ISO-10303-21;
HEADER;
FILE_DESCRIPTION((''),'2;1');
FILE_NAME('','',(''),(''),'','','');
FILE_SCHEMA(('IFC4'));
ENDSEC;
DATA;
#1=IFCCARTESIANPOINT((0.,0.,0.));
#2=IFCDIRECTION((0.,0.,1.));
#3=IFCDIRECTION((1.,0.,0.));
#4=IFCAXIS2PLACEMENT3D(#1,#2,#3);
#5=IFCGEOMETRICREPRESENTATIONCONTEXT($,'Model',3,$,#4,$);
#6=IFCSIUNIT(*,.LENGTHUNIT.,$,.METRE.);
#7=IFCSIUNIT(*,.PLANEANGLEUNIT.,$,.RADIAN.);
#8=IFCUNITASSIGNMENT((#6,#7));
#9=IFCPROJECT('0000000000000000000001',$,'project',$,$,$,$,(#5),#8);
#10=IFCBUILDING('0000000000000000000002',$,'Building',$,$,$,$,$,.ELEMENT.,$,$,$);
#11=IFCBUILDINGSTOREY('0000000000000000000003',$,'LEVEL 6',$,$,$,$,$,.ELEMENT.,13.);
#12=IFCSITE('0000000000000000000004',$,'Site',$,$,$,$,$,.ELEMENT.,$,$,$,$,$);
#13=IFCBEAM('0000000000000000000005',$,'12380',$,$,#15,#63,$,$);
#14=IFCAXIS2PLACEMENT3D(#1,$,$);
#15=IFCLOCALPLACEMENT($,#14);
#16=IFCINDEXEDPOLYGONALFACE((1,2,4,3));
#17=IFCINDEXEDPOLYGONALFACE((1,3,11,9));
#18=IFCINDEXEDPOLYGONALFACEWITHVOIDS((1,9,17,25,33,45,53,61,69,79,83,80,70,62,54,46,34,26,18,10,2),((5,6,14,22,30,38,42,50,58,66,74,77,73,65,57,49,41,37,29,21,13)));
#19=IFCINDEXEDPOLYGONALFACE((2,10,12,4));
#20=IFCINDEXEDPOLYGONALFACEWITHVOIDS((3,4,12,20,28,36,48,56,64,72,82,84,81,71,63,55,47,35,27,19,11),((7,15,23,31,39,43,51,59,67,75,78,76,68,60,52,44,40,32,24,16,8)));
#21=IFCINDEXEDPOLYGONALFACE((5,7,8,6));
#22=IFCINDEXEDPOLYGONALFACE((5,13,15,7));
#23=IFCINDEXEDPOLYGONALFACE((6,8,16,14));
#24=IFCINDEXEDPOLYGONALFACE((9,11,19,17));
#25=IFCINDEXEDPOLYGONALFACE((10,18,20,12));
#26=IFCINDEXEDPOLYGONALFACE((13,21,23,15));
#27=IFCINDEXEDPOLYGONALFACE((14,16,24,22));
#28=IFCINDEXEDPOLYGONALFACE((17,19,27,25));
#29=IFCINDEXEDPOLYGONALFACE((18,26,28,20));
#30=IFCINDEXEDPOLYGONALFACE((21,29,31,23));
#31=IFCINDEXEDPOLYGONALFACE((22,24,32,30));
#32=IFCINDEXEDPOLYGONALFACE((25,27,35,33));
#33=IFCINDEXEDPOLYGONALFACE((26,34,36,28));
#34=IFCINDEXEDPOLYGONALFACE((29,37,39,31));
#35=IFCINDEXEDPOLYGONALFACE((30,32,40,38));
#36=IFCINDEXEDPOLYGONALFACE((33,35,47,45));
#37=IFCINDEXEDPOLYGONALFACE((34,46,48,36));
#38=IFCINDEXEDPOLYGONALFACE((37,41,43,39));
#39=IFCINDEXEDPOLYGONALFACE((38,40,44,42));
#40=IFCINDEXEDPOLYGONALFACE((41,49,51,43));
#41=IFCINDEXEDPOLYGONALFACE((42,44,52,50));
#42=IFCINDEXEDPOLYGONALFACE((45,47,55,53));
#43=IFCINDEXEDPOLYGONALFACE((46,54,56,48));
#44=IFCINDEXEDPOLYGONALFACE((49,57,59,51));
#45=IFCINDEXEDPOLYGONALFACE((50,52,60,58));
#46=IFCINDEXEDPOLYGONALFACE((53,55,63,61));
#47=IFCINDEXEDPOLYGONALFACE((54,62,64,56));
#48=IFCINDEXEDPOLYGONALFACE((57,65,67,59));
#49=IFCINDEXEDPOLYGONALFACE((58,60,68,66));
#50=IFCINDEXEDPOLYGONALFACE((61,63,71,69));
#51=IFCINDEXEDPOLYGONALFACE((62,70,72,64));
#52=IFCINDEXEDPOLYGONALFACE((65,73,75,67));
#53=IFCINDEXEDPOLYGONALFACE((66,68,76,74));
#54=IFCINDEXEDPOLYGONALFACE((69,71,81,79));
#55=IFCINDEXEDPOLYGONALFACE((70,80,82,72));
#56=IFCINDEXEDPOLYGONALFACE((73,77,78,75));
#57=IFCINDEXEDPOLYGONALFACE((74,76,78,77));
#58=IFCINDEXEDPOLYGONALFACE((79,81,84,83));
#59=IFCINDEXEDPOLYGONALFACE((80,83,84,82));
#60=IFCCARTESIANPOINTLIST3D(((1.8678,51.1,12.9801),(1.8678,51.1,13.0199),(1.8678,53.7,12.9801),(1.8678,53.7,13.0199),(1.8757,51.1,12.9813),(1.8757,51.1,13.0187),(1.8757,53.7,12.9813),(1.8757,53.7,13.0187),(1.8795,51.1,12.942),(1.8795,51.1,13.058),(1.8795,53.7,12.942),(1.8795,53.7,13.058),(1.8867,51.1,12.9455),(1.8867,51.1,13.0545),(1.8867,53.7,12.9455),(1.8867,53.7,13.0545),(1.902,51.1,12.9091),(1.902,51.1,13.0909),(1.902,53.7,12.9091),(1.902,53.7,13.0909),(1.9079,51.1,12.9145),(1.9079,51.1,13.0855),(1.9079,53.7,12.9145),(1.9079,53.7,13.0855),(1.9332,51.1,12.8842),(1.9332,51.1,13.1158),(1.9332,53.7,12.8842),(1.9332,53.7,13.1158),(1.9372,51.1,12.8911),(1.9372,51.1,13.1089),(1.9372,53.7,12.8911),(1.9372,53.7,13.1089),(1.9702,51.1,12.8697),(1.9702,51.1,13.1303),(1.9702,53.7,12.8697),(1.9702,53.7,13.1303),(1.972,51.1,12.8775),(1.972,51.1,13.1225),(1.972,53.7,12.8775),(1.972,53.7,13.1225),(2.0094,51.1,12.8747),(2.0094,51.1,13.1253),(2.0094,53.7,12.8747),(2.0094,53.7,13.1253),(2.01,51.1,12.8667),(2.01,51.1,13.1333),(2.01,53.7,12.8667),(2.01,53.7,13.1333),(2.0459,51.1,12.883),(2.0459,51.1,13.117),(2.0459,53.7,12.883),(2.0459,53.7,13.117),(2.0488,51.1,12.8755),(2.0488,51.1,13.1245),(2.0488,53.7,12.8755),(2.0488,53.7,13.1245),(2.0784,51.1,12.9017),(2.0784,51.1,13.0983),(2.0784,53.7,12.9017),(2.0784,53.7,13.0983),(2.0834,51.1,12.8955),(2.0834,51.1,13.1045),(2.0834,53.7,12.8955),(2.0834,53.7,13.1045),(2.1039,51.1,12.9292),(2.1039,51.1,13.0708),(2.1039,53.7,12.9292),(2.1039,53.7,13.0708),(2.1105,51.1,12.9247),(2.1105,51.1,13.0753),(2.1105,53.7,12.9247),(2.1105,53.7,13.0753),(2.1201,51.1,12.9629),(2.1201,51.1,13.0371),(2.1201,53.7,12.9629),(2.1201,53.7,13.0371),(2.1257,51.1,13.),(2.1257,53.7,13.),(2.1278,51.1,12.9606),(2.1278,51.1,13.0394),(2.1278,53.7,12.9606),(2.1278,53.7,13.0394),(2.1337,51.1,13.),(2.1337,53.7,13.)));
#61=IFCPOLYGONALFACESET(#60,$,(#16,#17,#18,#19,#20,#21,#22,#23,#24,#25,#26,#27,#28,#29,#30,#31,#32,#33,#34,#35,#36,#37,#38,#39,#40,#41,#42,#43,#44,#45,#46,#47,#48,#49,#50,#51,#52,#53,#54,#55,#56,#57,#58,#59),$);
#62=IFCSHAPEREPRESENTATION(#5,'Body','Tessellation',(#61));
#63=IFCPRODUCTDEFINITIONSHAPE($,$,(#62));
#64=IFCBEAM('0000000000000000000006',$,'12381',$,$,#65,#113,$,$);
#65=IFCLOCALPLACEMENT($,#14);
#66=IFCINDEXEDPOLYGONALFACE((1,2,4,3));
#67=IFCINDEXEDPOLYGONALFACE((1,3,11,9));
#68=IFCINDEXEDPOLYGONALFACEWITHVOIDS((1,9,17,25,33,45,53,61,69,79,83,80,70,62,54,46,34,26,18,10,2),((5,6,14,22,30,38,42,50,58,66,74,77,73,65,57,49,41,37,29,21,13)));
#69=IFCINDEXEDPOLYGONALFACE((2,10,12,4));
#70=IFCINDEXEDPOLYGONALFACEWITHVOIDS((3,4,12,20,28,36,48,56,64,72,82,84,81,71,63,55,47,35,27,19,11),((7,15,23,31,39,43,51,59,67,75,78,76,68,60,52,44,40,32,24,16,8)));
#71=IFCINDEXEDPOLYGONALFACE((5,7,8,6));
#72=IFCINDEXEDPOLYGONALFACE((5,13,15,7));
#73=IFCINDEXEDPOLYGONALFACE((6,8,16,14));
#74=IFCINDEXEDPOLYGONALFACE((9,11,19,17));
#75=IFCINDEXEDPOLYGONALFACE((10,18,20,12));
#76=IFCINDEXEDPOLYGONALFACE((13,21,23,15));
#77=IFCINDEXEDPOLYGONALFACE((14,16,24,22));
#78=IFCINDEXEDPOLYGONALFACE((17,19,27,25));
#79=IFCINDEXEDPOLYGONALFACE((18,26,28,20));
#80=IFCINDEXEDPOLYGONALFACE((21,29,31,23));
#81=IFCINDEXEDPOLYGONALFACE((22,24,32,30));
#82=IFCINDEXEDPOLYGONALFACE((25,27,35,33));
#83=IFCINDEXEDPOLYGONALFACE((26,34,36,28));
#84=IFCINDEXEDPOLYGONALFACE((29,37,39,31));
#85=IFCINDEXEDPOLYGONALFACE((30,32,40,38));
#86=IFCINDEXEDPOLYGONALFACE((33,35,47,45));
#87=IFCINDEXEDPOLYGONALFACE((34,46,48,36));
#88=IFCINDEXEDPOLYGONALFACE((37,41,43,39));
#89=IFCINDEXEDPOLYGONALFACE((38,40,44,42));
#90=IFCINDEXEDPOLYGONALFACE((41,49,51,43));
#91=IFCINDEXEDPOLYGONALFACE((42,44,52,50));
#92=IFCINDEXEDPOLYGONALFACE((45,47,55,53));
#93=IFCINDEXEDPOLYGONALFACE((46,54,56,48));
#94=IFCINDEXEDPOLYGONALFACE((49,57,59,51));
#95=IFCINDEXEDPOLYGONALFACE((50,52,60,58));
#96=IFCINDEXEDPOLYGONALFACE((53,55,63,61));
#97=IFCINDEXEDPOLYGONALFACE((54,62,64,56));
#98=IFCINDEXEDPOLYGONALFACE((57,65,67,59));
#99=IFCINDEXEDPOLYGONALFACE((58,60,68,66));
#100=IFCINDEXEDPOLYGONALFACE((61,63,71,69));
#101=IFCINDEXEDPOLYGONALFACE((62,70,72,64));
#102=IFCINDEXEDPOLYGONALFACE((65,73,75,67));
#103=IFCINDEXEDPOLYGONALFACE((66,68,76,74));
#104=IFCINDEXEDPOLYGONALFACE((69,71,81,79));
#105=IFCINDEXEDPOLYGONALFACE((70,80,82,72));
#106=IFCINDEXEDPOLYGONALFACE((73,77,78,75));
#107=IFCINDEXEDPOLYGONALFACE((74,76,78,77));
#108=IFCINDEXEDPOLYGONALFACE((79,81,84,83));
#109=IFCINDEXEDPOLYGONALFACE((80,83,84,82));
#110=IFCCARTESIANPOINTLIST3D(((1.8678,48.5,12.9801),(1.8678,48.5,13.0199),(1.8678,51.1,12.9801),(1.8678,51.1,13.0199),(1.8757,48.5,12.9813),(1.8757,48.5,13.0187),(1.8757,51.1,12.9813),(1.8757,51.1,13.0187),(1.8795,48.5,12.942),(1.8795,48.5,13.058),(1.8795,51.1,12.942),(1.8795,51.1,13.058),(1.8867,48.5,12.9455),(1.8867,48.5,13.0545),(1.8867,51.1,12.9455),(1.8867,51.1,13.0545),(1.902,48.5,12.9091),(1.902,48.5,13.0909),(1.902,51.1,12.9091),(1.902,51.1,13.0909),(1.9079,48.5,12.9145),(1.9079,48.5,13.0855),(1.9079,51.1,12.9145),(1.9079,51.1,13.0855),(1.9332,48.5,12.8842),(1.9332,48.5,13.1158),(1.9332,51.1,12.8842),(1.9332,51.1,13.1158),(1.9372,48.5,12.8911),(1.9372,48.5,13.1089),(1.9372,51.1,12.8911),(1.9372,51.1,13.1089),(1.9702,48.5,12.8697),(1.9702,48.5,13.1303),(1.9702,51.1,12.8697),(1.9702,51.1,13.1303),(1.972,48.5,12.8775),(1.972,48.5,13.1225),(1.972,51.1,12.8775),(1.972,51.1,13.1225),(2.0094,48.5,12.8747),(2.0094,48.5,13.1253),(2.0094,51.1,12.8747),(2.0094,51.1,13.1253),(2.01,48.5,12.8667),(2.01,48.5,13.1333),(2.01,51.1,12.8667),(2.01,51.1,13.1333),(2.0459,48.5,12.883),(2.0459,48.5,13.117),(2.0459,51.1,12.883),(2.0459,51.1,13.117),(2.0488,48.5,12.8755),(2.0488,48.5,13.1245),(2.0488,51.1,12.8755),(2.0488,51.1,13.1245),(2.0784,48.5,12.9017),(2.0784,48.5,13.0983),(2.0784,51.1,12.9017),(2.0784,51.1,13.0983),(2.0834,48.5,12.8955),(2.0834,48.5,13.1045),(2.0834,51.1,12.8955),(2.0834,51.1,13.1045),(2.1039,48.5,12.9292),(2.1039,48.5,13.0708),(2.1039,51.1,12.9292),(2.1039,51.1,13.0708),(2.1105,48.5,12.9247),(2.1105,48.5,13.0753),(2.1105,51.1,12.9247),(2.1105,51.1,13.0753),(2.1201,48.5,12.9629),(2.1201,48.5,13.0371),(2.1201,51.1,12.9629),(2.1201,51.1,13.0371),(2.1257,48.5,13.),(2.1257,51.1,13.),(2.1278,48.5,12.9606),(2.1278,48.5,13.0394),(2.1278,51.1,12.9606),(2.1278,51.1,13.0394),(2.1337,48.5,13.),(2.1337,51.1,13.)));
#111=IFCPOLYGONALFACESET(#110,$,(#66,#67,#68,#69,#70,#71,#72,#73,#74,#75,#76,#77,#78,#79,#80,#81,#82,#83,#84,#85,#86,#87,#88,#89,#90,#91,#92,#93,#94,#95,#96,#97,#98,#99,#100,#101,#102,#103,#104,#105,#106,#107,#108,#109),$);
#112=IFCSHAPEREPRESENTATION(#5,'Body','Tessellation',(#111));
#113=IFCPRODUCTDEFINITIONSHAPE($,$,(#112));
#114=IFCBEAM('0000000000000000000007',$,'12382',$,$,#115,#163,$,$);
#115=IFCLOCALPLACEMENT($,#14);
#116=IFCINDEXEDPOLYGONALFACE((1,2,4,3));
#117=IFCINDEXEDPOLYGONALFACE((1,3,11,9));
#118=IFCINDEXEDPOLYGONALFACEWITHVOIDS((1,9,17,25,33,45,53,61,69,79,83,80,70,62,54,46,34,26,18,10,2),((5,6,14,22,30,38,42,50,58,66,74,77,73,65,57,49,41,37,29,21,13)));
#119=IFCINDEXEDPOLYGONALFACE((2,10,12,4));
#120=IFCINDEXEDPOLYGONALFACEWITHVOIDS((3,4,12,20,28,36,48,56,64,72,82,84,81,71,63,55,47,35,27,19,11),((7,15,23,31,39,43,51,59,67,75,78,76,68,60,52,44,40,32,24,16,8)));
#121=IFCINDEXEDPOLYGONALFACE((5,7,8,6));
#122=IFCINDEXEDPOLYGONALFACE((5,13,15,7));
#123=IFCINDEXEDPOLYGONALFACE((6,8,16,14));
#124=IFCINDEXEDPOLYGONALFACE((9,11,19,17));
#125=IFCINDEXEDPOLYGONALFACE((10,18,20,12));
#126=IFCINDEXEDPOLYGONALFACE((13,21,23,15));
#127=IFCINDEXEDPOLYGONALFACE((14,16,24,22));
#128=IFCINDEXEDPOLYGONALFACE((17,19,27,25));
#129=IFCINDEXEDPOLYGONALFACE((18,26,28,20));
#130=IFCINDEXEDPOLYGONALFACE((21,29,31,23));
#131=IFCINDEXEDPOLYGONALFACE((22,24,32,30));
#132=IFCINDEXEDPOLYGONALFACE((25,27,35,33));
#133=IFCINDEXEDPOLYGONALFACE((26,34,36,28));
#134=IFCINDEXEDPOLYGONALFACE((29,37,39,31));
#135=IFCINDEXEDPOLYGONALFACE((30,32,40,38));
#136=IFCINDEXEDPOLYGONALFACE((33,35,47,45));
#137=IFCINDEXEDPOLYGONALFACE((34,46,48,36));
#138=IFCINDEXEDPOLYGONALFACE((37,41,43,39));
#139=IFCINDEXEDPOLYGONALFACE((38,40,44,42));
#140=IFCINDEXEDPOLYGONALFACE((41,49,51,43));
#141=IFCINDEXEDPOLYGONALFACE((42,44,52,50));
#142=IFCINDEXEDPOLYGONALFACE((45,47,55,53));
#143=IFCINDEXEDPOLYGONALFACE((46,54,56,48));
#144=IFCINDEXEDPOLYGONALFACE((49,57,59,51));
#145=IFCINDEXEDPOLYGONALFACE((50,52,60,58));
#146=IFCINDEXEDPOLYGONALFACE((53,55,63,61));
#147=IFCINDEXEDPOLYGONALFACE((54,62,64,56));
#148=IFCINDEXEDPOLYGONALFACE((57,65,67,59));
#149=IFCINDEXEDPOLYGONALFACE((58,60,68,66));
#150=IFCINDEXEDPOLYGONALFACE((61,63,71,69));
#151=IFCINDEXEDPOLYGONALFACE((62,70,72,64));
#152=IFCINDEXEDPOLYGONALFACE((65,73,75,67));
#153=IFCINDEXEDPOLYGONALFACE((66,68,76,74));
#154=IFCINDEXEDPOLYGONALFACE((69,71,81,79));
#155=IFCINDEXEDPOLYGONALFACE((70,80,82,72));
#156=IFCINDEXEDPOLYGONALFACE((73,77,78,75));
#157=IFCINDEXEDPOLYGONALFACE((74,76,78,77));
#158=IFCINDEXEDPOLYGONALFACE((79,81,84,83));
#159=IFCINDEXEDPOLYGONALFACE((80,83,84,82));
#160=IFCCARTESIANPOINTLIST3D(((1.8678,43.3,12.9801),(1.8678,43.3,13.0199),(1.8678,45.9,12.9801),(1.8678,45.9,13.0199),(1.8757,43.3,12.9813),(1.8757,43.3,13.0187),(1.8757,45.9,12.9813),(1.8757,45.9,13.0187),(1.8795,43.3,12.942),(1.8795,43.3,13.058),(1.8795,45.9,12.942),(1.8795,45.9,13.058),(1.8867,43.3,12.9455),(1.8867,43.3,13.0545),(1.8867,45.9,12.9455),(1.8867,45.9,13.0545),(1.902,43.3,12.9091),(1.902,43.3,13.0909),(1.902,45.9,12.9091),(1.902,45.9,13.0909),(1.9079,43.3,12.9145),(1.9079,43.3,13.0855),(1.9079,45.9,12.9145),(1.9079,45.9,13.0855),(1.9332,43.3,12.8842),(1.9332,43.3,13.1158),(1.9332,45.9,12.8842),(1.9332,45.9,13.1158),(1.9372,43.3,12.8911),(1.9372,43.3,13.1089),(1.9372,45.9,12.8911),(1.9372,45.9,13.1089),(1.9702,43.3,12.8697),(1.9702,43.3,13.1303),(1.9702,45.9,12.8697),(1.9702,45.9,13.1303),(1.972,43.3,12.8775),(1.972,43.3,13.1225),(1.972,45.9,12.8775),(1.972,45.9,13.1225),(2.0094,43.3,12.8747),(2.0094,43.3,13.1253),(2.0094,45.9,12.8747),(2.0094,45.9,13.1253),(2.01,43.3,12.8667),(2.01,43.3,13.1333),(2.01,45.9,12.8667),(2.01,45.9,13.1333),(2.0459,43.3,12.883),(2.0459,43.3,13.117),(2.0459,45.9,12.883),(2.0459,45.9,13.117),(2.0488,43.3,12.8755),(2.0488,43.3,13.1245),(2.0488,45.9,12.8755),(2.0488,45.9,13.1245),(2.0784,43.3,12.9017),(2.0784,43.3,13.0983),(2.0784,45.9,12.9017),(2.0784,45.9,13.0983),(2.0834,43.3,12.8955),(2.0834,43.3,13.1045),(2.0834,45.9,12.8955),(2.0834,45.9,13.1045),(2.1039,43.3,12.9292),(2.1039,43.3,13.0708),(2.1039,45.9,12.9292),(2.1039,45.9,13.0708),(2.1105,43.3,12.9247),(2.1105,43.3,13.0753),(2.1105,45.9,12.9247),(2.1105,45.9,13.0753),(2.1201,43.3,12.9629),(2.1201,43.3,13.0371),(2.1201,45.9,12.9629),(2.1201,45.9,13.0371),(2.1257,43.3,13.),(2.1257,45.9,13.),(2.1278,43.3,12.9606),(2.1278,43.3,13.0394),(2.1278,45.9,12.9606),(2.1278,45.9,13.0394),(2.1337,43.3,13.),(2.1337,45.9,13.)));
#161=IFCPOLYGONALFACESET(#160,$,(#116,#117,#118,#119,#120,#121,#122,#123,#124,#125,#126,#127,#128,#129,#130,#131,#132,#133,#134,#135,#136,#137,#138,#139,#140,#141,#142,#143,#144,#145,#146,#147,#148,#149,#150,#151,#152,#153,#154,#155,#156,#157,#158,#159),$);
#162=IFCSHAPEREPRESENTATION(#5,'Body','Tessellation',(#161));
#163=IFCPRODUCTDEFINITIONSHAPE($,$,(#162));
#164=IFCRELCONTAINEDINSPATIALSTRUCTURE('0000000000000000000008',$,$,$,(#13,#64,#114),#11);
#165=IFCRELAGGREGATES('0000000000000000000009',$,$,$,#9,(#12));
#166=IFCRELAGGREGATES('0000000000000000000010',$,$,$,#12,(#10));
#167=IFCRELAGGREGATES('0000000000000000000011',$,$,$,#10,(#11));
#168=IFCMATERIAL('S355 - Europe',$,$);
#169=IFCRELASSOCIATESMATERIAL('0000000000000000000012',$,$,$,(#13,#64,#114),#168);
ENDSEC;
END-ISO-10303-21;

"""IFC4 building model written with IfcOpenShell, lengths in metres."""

from ifc_helpers import new_model, si_unit, frame, origin_with_axes, origin_2d_with_axis, place, context, project, spatial, hollow_circle, extrude, material, material_profile, profile_set, profile_usage, element, save


model = new_model("IFC4")

# Units and contexts
model_context = context("Model", 3, world=origin_with_axes())
ifc_project = project(units=[si_unit("LENGTHUNIT", "METRE"), si_unit("PLANEANGLEUNIT", "RADIAN")], contexts=[model_context])

# Site, building, storey
site = spatial("IfcSite", under=ifc_project, Name="Site", CompositionType="ELEMENT")
building = spatial("IfcBuilding", under=site, Name="Building", CompositionType="ELEMENT")
storey = spatial("IfcBuildingStorey", under=building, Name="LEVEL 6", CompositionType="ELEMENT", Elevation=13.0)

# Shared definitions
ifc_material = material(Name="S355 - Europe")

# Beams
ifc_material_profile_1 = material_profile(ifc_material, hollow_circle(Radius=0.1337, WallThickness=0.008, at=origin_2d_with_axis()))
ifc_profile_set_1 = profile_set([ifc_material_profile_1])
ifc_profile_usage_1 = profile_usage(ifc_profile_set_1, cardinal=10)
beam_1_placement = place(None, frame((2.0, 53.7, 13.0), z_axis=(0.0, -1.0, 0.0), x_axis=(1.0, 0.0, 0.0)))
element("IfcBeam", 1, at=beam_1_placement, inside=storey, material=ifc_profile_usage_1, Name="12380", context=model_context, shape_type="SweptSolid", body=[
    extrude(hollow_circle(Radius=0.1337, WallThickness=0.008, at=origin_2d_with_axis()), origin_with_axes(), (0.0, 0.0, 1.0), 2.6),
])
ifc_material_profile_2 = material_profile(ifc_material, hollow_circle(Radius=0.1337, WallThickness=0.008, at=origin_2d_with_axis()))
ifc_profile_set_2 = profile_set([ifc_material_profile_2])
ifc_profile_usage_2 = profile_usage(ifc_profile_set_2, cardinal=10)
beam_2_placement = place(None, frame((2.0, 51.1, 13.0), z_axis=(0.0, -1.0, 0.0), x_axis=(1.0, 0.0, 0.0)))
element("IfcBeam", 2, at=beam_2_placement, inside=storey, material=ifc_profile_usage_2, Name="12381", context=model_context, shape_type="SweptSolid", body=[
    extrude(hollow_circle(Radius=0.1337, WallThickness=0.008, at=origin_2d_with_axis()), origin_with_axes(), (0.0, 0.0, 1.0), 2.6),
])
ifc_material_profile_3 = material_profile(ifc_material, hollow_circle(Radius=0.1337, WallThickness=0.008, at=origin_2d_with_axis()))
ifc_profile_set_3 = profile_set([ifc_material_profile_3])
ifc_profile_usage_3 = profile_usage(ifc_profile_set_3, cardinal=10)
beam_3_placement = place(None, frame((2.0, 45.9, 13.0), z_axis=(0.0, -1.0, 0.0), x_axis=(1.0, 0.0, 0.0)))
element("IfcBeam", 3, at=beam_3_placement, inside=storey, material=ifc_profile_usage_3, Name="12382", context=model_context, shape_type="SweptSolid", body=[
    extrude(hollow_circle(Radius=0.1337, WallThickness=0.008, at=origin_2d_with_axis()), origin_with_axes(), (0.0, 0.0, 1.0), 2.6),
])

save(model, "model.ifc")
